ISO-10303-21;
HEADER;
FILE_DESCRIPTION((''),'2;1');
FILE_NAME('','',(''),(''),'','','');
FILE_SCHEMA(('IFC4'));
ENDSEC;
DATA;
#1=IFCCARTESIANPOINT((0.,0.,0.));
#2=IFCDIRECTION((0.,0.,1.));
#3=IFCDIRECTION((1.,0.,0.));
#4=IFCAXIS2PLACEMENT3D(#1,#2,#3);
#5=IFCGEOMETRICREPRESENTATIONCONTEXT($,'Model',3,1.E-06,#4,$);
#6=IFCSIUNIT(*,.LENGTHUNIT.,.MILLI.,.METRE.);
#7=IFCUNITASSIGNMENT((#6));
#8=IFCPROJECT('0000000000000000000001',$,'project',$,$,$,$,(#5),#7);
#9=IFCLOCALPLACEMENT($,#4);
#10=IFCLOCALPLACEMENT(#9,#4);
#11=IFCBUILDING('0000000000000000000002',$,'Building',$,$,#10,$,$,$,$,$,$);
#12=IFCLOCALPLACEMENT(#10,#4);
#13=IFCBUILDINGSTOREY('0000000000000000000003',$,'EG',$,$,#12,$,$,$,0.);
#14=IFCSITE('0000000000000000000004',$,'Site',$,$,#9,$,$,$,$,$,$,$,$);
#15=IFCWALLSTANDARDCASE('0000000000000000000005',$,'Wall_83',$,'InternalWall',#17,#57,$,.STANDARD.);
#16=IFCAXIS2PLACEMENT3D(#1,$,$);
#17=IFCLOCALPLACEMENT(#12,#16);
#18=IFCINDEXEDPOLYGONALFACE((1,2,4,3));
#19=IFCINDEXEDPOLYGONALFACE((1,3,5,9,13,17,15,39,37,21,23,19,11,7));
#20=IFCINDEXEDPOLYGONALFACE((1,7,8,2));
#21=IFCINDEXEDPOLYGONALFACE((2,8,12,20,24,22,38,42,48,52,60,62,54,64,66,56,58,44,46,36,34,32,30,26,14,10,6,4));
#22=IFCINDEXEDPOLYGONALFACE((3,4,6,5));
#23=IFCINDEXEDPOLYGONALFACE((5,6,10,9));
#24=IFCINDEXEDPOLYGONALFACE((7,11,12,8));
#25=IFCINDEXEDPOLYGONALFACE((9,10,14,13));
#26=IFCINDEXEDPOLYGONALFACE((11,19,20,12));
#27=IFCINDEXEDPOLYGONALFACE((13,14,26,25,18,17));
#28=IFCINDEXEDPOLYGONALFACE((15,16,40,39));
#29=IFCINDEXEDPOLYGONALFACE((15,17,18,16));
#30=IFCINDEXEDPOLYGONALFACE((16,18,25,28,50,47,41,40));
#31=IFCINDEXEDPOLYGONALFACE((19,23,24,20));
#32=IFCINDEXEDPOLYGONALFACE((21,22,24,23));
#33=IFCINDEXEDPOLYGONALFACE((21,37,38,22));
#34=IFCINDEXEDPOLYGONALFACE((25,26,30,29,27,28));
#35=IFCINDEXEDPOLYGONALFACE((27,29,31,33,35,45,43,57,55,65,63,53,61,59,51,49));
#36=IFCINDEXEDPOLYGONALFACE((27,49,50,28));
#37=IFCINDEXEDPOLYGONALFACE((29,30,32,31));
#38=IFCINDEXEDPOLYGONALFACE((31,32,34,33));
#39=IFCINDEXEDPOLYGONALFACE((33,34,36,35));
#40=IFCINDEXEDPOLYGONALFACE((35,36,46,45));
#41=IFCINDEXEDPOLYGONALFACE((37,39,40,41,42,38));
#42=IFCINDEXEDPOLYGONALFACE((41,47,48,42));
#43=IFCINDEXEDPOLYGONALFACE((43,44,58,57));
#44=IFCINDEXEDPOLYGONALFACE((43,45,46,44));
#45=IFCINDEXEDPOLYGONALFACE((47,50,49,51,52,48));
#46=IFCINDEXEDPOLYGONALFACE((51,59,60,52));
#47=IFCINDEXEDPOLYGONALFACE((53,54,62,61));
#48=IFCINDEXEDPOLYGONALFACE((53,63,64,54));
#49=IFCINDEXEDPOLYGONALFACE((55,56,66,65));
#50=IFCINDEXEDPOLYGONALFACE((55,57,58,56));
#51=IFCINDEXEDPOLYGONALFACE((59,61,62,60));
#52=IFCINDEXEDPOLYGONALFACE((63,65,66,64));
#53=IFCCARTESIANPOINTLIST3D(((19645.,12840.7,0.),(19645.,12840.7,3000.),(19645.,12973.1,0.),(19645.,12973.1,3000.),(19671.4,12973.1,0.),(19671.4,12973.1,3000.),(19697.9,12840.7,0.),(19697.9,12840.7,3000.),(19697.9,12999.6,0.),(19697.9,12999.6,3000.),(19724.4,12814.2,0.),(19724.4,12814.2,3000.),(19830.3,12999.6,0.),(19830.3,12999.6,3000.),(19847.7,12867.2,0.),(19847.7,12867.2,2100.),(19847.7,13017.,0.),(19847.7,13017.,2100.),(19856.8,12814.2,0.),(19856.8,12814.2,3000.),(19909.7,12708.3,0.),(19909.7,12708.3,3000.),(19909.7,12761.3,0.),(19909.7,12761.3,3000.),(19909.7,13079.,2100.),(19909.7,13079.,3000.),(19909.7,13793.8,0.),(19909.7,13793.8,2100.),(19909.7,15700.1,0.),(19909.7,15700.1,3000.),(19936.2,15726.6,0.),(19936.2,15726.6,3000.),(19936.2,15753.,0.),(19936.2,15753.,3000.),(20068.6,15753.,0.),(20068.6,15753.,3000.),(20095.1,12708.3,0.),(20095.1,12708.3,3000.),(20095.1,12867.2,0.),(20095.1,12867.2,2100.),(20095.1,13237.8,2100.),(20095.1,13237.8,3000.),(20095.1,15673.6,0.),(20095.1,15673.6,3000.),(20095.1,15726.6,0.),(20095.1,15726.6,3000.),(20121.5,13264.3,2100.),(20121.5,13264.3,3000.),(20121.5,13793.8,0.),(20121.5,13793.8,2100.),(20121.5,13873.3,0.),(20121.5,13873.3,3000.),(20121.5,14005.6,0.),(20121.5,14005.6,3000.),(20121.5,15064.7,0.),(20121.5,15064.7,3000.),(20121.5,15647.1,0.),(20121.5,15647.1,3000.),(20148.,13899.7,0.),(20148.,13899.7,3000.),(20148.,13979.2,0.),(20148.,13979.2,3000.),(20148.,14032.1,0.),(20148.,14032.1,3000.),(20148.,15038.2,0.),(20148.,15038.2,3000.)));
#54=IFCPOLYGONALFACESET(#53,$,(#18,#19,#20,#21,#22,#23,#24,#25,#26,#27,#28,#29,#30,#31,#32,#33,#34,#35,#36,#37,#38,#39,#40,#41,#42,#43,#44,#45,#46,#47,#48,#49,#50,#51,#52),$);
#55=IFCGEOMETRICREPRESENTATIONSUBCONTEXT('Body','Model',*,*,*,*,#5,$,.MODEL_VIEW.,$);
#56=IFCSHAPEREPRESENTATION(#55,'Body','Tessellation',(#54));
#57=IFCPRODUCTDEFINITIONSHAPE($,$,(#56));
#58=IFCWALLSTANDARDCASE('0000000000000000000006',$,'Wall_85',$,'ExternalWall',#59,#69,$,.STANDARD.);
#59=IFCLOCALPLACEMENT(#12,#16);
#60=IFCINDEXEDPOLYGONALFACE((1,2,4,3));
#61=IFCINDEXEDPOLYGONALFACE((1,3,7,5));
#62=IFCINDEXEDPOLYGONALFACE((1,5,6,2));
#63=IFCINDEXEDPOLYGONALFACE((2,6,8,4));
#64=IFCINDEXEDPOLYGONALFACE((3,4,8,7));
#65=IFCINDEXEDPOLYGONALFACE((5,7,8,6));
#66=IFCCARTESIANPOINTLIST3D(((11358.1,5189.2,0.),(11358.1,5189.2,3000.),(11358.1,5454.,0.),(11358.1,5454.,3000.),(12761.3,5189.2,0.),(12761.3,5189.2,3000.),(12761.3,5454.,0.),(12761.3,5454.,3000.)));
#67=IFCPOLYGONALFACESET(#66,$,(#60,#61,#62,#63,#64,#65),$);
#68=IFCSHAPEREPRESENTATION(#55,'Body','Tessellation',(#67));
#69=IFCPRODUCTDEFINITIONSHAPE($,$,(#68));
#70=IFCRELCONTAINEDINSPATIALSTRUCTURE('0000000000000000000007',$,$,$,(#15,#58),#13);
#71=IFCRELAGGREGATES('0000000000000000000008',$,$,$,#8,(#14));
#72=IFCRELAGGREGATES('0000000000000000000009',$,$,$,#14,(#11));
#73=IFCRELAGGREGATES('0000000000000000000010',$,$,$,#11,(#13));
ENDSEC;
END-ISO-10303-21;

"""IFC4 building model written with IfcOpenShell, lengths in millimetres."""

from ifc_helpers import new_model, si_unit, frame, origin_with_axes, place, context, subcontext, project, spatial, polyline, rectangle, outline, extrude, element, save


model = new_model("IFC4")

# Units and contexts
model_context = context("Model", 3, precision=1e-06, world=origin_with_axes())
body_context = subcontext(model_context, "Body", "Model", "MODEL_VIEW")
ifc_project = project(units=[si_unit("LENGTHUNIT", "METRE", prefix="MILLI")], contexts=[model_context])

# Site, building, storey
site_placement = place(None, origin_with_axes())
site = spatial("IfcSite", under=ifc_project, at=site_placement, Name="Site")
building_placement = place(site_placement, origin_with_axes())
building = spatial("IfcBuilding", under=site, at=building_placement, Name="Building")
storey_placement = place(building_placement, origin_with_axes())
storey = spatial("IfcBuildingStorey", under=building, at=storey_placement, Name="EG", Elevation=0.0)

# Wall, opening
wall_1_placement = place(storey_placement, origin_with_axes())
wall_1 = element("IfcWallStandardCase", 1, at=wall_1_placement, inside=storey, Name="Wall_83", ObjectType="InternalWall", PredefinedType="STANDARD", context=body_context, shape_type="SweptSolid", body=[
    extrude(outline(polyline([(19909.7, 12708.3, 0.0), (19909.7, 12761.3, 0.0), (19856.8, 12814.2, 0.0), (19724.4, 12814.2, 0.0), (19697.9, 12840.7, 0.0), (19645.0, 12840.7, 0.0), (19645.0, 12973.1, 0.0), (19671.4, 12973.1, 0.0), (19697.9, 12999.6, 0.0), (19830.3, 12999.6, 0.0), (19909.7, 13079.0, 0.0), (19909.7, 15700.1, 0.0), (19936.2, 15726.6, 0.0), (19936.2, 15753.0, 0.0), (20068.6, 15753.0, 0.0), (20095.1, 15726.6, 0.0), (20095.1, 15673.6, 0.0), (20121.5, 15647.1, 0.0), (20121.5, 15064.7, 0.0), (20148.0, 15038.2, 0.0), (20148.0, 14032.1, 0.0), (20121.5, 14005.6, 0.0), (20148.0, 13979.2, 0.0), (20148.0, 13899.7, 0.0), (20121.5, 13873.3, 0.0), (20121.5, 13264.3, 0.0), (20095.1, 13237.8, 0.0), (20095.1, 12708.3, 0.0), (19909.7, 12708.3, 0.0)])), origin_with_axes(), (0.0, 0.0, 1.0), 3000.0),
])
opening_1_placement = place(wall_1_placement, origin_with_axes())
element("IfcOpeningElement", 2, at=opening_1_placement, inside=storey, cuts=wall_1, context=body_context, shape_type="SweptSolid", body=[
    extrude(rectangle(XDim=926.6, YDim=300.0), frame((19997.7, 13330.5, 0.0), z_axis=(0.0, 0.0, 1.0), x_axis=(0.0, -1.0, 0.0)), (0.0, 0.0, 1.0), 2100.0),
])

# Wall
for number, where, z_axis, x_axis, name in (
    (3, (0.0, 0.0, 0.0), (0.0, 0.0, 1.0), (1.0, 0.0, 0.0), "Wall_85"),
):
    element("IfcWallStandardCase", number, at=place(storey_placement, frame(where, z_axis=z_axis, x_axis=x_axis)), inside=storey, Name=name, ObjectType="ExternalWall", PredefinedType="STANDARD", context=body_context, shape_type="SweptSolid", body=[
        extrude(outline(polyline([(11358.1, 5189.2, 0.0), (11358.1, 5454.0, 0.0), (12761.3, 5454.0, 0.0), (12761.3, 5189.2, 0.0), (11358.1, 5189.2, 0.0)])), origin_with_axes(), (0.0, 0.0, 1.0), 3000.0),
    ])

save(model, "model.ifc")
